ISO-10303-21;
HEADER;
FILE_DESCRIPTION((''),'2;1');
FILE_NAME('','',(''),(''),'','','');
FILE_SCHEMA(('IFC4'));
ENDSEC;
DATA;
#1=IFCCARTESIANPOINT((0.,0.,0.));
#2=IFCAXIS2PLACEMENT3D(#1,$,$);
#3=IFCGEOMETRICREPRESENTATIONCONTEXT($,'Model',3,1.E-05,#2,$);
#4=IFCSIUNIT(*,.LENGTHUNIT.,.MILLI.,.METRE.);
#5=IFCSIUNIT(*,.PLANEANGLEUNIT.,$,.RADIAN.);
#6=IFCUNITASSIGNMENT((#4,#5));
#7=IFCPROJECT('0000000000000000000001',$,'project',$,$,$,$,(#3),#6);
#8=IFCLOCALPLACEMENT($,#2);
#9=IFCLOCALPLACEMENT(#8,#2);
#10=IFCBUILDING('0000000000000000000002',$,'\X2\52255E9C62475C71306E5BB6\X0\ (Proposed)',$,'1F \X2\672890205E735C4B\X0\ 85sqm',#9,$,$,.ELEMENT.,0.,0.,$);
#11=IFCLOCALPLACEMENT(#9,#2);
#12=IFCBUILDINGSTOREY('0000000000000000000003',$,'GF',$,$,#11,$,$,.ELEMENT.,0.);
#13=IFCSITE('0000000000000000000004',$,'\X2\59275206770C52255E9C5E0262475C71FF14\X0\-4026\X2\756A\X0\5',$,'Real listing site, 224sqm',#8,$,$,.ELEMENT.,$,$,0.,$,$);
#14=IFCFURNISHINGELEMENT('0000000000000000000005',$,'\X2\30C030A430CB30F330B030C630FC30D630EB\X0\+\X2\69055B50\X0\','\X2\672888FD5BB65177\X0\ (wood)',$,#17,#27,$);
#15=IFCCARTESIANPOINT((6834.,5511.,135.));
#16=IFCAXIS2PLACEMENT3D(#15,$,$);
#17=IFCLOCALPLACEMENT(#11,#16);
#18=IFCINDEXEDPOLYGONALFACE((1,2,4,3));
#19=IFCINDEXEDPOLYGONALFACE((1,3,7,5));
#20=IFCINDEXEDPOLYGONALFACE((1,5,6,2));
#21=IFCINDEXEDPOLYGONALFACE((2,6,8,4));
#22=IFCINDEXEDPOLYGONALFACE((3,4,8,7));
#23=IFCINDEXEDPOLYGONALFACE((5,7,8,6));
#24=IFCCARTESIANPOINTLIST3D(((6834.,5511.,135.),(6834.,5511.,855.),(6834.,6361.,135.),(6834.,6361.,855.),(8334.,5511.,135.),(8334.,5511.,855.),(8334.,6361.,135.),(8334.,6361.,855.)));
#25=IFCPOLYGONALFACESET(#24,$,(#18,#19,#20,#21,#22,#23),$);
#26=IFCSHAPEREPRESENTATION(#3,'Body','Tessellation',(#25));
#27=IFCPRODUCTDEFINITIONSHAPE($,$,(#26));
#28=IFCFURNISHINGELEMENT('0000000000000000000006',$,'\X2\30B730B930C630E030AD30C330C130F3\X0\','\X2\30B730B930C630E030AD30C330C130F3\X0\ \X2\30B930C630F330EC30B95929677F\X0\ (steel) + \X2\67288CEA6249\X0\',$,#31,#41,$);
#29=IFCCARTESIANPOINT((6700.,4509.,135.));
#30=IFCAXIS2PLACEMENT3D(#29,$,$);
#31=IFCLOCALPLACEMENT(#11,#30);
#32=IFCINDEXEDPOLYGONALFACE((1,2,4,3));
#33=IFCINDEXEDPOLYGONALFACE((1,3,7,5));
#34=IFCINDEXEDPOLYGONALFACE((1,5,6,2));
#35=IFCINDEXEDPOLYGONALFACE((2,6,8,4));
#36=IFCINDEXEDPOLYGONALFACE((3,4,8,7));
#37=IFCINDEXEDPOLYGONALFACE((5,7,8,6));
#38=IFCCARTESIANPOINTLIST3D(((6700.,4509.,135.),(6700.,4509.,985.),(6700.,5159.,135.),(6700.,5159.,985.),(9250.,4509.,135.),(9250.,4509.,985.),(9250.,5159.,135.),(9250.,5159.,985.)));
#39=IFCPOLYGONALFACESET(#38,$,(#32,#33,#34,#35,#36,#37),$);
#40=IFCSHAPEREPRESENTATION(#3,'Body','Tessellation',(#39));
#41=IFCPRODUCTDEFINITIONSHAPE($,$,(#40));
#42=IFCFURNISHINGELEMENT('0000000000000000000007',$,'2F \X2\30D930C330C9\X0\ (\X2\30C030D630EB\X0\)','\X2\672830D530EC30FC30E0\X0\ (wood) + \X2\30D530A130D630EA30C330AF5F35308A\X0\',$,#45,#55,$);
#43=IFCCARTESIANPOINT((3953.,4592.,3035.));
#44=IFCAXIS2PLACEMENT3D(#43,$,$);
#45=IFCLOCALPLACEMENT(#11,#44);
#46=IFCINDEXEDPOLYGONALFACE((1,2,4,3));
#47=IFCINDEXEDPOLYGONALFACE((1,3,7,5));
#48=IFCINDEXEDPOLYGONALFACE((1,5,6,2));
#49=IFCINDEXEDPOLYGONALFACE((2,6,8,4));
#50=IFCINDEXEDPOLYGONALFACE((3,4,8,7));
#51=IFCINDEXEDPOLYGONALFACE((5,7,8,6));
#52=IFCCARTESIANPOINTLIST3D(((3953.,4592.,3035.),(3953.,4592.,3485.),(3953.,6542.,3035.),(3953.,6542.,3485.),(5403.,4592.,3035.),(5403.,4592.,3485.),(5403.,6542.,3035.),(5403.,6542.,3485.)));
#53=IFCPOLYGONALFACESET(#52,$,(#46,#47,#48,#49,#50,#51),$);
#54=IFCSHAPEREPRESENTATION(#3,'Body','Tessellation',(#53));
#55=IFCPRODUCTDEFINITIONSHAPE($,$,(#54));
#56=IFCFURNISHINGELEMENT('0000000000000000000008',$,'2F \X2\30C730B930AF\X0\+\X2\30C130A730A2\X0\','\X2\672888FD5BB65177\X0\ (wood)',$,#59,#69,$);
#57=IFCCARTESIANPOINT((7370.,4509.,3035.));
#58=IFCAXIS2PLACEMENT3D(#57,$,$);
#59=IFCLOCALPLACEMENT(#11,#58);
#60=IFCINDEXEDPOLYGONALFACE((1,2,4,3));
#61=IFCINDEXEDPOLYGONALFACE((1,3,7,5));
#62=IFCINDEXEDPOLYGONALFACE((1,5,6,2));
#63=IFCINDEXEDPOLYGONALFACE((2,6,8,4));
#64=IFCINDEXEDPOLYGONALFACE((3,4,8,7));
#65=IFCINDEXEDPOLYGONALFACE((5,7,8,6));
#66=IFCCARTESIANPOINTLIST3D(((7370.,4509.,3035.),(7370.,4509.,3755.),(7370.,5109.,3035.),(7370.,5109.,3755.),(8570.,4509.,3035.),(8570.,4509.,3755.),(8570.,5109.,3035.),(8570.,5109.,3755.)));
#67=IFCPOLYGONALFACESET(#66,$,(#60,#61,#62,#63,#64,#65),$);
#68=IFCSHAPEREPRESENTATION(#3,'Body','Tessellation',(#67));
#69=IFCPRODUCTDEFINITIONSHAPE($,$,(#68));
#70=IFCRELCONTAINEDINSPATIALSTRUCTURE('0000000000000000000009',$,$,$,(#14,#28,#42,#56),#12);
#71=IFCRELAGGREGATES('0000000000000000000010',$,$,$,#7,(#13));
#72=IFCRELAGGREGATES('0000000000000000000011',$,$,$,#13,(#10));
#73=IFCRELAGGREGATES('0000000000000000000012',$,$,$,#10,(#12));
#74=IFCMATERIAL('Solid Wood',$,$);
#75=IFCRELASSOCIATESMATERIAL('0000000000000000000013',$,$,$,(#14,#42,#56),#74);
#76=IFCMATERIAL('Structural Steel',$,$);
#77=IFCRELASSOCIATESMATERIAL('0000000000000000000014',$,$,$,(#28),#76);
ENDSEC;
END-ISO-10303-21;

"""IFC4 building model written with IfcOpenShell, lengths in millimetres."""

from ifc_helpers import new_model, si_unit, frame, frame_2d, origin, place, context, project, spatial, rectangle, extrude, material, element, save


model = new_model("IFC4")

# Units and contexts
model_context = context("Model", 3, precision=1e-05, world=origin())
ifc_project = project(units=[si_unit("LENGTHUNIT", "METRE", prefix="MILLI"), si_unit("PLANEANGLEUNIT", "RADIAN")], contexts=[model_context])

# Site, building, storey
site_placement = place(None, origin())
site = spatial("IfcSite", under=ifc_project, at=site_placement, Name="大分県別府市扇山４-4026番5", ObjectType="Real listing site, 224sqm", CompositionType="ELEMENT", RefElevation=0.0)
building_placement = place(site_placement, origin())
building = spatial("IfcBuilding", under=site, at=building_placement, Name="別府扇山の家 (Proposed)", ObjectType="1F 木造平屋 85sqm", CompositionType="ELEMENT", ElevationOfRefHeight=0.0, ElevationOfTerrain=0.0)
storey_placement = place(building_placement, origin())
storey = spatial("IfcBuildingStorey", under=building, at=storey_placement, Name="GF", CompositionType="ELEMENT", Elevation=0.0)

# Shared definitions
ifc_material_1 = material(Name="Solid Wood")

# Shared definitions
ifc_material_2 = material(Name="Structural Steel")

# Furnishing elements
furnishing_1_placement = place(storey_placement, frame((6834.0, 5511.0, 135.0)))
element("IfcFurnishingElement", 1, at=furnishing_1_placement, inside=storey, material=ifc_material_1, Name="ダイニングテーブル+椅子", Description="木製家具 (wood)", context=model_context, shape_type="SweptSolid", body=[
    extrude(rectangle(XDim=1500.0, YDim=850.0, at=frame_2d((750.0, 425.0))), frame((6834.0, 5511.0, 135.0)), (0.0, 0.0, 1.0), 720.0),
])
furnishing_2_placement = place(storey_placement, frame((6700.0, 4509.0, 135.0)))
element("IfcFurnishingElement", 2, at=furnishing_2_placement, inside=storey, material=ifc_material_2, Name="システムキッチン", Description="システムキッチン ステンレス天板 (steel) + 木質扉", context=model_context, shape_type="SweptSolid", body=[
    extrude(rectangle(XDim=2550.0, YDim=650.0, at=frame_2d((1275.0, 325.0))), frame((6700.0, 4509.0, 135.0)), (0.0, 0.0, 1.0), 850.0),
])
furnishing_3_placement = place(storey_placement, frame((3953.0, 4592.0, 3035.0)))
element("IfcFurnishingElement", 3, at=furnishing_3_placement, inside=storey, material=ifc_material_1, Name="2F ベッド (ダブル)", Description="木フレーム (wood) + ファブリック張り", context=model_context, shape_type="SweptSolid", body=[
    extrude(rectangle(XDim=1450.0, YDim=1950.0, at=frame_2d((725.0, 975.0))), frame((3953.0, 4592.0, 3035.0)), (0.0, 0.0, 1.0), 450.0),
])
furnishing_4_placement = place(storey_placement, frame((7370.0, 4509.0, 3035.0)))
element("IfcFurnishingElement", 4, at=furnishing_4_placement, inside=storey, material=ifc_material_1, Name="2F デスク+チェア", Description="木製家具 (wood)", context=model_context, shape_type="SweptSolid", body=[
    extrude(rectangle(XDim=1200.0, YDim=600.0, at=frame_2d((600.0, 300.0))), frame((7370.0, 4509.0, 3035.0)), (0.0, 0.0, 1.0), 720.0),
])

save(model, "model.ifc")
